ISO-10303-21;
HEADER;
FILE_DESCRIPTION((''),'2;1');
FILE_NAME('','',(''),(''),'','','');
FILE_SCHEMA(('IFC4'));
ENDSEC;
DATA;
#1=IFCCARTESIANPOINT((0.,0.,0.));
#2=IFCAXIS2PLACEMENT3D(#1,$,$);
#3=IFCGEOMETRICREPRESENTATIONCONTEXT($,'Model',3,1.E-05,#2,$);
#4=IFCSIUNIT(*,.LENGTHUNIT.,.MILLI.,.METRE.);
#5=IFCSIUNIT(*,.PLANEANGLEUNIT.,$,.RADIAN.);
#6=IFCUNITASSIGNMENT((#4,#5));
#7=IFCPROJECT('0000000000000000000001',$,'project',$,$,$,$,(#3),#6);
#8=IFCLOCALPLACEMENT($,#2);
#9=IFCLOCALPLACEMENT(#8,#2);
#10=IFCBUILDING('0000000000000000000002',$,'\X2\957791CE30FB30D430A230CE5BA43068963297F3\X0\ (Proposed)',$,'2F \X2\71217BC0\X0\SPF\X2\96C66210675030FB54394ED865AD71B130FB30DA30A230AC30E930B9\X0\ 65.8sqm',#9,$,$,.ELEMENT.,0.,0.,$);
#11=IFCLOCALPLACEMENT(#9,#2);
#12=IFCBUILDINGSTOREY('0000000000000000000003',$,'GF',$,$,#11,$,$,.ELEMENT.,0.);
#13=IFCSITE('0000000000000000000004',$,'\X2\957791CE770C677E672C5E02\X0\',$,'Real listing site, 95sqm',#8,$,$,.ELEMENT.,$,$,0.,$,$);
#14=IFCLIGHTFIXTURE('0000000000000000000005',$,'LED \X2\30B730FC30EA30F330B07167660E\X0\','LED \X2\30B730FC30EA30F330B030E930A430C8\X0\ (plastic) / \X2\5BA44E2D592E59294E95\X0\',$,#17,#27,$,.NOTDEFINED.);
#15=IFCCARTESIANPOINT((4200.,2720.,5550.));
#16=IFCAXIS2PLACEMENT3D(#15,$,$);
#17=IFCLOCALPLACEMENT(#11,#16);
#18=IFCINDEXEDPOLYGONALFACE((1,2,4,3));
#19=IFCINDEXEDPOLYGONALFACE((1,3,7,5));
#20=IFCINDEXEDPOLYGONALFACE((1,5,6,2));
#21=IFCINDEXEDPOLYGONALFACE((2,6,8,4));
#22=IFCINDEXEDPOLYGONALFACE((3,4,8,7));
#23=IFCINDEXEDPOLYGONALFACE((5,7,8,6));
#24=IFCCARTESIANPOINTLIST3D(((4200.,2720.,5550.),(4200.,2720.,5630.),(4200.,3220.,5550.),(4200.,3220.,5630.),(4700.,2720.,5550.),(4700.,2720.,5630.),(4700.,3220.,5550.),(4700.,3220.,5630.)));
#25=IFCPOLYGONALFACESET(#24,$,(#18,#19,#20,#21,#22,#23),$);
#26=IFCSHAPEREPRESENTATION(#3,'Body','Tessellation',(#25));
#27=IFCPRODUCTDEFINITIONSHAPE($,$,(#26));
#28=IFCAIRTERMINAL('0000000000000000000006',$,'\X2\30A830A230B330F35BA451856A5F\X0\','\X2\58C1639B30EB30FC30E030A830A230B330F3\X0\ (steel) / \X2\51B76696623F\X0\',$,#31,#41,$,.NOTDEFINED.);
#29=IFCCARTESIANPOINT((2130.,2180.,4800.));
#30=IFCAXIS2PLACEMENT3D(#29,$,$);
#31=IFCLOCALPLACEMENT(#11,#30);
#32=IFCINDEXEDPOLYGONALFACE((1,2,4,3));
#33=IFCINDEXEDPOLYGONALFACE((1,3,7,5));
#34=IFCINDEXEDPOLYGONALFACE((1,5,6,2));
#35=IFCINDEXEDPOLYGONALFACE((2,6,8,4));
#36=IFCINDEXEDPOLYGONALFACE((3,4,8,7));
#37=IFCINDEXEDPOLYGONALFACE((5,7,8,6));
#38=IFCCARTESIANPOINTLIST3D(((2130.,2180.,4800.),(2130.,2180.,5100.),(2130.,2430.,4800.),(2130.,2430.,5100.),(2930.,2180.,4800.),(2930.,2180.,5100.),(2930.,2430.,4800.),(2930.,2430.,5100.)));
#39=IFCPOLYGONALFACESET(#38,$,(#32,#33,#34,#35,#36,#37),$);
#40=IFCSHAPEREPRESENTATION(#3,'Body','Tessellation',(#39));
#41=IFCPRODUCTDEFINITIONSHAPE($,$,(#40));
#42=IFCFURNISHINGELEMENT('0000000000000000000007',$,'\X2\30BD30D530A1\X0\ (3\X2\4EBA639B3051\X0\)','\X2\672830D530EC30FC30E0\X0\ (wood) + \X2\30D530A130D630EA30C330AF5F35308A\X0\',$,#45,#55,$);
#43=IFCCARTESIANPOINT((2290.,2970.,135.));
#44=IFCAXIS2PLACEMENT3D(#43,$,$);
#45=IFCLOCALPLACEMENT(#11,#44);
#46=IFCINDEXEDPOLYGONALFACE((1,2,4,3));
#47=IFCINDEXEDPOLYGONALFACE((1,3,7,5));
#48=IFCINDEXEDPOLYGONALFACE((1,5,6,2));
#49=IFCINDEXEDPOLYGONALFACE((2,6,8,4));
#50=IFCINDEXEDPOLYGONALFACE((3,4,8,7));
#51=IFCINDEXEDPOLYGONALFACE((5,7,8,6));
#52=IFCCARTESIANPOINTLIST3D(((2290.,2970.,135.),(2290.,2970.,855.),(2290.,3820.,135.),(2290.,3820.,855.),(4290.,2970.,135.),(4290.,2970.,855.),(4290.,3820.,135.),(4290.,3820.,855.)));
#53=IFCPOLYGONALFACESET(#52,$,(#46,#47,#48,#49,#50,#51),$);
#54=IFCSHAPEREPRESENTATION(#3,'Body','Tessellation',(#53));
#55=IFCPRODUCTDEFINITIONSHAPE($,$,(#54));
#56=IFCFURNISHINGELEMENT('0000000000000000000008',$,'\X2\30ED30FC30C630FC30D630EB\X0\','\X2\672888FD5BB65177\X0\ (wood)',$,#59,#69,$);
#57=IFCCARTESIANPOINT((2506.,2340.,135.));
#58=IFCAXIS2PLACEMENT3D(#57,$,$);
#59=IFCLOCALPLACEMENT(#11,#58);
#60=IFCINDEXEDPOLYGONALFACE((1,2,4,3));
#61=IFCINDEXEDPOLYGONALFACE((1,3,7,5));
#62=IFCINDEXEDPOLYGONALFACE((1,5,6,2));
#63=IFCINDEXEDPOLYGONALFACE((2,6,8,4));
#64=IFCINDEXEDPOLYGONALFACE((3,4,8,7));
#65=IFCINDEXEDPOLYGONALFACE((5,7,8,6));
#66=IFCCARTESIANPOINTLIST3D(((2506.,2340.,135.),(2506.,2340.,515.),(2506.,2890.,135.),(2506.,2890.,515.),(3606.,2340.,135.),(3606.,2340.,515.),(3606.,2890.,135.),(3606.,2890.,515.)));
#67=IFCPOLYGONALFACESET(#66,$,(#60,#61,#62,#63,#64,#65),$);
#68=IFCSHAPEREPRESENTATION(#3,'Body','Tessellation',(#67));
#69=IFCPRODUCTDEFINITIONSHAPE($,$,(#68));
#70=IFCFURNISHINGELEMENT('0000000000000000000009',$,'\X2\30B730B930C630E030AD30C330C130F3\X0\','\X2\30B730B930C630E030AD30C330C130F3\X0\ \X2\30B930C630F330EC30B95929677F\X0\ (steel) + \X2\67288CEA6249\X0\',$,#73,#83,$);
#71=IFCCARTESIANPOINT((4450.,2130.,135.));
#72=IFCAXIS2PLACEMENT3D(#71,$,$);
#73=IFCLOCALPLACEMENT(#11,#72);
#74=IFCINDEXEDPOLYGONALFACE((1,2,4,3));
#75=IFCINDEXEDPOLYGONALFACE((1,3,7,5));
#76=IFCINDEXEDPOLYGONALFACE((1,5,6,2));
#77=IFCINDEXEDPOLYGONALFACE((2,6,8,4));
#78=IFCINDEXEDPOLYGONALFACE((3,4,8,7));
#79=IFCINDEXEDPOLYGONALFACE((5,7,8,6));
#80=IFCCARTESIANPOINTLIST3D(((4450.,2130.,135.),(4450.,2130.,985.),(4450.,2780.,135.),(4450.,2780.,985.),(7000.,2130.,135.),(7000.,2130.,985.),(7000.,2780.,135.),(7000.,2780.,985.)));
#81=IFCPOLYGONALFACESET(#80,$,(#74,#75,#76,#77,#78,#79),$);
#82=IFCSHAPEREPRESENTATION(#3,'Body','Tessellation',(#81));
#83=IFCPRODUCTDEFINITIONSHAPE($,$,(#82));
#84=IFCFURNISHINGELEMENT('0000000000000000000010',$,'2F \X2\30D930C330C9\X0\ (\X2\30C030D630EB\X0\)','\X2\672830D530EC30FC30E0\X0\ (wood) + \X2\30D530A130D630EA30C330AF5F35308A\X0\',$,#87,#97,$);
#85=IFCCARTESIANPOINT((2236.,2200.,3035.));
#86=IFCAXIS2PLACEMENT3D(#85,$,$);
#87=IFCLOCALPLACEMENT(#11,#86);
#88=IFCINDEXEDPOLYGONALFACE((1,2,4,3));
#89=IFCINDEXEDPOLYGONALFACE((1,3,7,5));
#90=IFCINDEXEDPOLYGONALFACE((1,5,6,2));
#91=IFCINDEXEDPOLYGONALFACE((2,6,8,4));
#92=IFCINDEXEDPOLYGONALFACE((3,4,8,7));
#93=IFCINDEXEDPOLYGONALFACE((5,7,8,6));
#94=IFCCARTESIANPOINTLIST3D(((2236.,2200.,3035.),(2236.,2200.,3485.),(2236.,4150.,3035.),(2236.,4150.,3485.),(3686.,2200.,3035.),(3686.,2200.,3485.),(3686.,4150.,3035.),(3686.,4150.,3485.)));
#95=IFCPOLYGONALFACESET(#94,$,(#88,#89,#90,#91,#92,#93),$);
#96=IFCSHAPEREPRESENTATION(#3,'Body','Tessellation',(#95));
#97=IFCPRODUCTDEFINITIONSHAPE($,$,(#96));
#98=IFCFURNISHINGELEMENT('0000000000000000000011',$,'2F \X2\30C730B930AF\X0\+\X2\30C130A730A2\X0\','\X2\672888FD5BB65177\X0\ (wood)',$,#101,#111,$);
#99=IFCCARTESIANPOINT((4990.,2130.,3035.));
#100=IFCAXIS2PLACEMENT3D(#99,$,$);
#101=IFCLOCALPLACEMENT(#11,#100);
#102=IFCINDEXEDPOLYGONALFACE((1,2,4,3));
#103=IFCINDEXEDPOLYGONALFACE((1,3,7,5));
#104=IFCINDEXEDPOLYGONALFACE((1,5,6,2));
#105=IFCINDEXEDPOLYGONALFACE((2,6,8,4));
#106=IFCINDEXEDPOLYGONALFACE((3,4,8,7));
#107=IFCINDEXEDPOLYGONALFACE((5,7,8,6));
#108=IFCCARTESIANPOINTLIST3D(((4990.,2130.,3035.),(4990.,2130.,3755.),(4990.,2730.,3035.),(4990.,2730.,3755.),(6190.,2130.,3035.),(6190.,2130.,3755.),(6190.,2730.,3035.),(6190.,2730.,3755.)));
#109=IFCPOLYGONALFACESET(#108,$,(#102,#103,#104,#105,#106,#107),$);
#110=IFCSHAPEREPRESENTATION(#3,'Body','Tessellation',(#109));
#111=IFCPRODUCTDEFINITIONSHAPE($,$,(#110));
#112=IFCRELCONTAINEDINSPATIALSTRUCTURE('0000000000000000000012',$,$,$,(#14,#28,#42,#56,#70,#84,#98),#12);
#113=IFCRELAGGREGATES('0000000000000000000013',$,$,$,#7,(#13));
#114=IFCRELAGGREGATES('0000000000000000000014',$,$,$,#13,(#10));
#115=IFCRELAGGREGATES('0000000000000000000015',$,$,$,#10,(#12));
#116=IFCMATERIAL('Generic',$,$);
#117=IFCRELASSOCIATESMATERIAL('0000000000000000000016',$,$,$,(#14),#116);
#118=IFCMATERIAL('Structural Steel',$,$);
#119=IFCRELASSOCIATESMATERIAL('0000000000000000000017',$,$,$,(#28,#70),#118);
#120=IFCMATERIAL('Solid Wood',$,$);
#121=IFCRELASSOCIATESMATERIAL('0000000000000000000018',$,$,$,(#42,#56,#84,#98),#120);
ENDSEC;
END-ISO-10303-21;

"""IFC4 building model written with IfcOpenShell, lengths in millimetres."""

from ifc_helpers import new_model, si_unit, frame, frame_2d, origin, place, context, project, spatial, rectangle, extrude, material, element, save


model = new_model("IFC4")

# Units and contexts
model_context = context("Model", 3, precision=1e-05, world=origin())
ifc_project = project(units=[si_unit("LENGTHUNIT", "METRE", prefix="MILLI"), si_unit("PLANEANGLEUNIT", "RADIAN")], contexts=[model_context])

# Site, building, storey
site_placement = place(None, origin())
site = spatial("IfcSite", under=ifc_project, at=site_placement, Name="長野県松本市", ObjectType="Real listing site, 95sqm", CompositionType="ELEMENT", RefElevation=0.0)
building_placement = place(site_placement, origin())
building = spatial("IfcBuilding", under=site, at=building_placement, Name="長野・ピアノ室と防音 (Proposed)", ObjectType="2F 無節SPF集成材・吹付断熱・ペアガラス 65.8sqm", CompositionType="ELEMENT", ElevationOfRefHeight=0.0, ElevationOfTerrain=0.0)
storey_placement = place(building_placement, origin())
storey = spatial("IfcBuildingStorey", under=building, at=storey_placement, Name="GF", CompositionType="ELEMENT", Elevation=0.0)

# Shared definitions
ifc_material_1 = material(Name="Solid Wood")

# Shared definitions
ifc_material_2 = material(Name="Generic")

# Shared definitions
ifc_material_3 = material(Name="Structural Steel")

# Light fixture
light_fixture_1_placement = place(storey_placement, frame((4200.0, 2720.0, 5550.0)))
element("IfcLightFixture", 1, at=light_fixture_1_placement, inside=storey, material=ifc_material_2, Name="LED シーリング照明", Description="LED シーリングライト (plastic) / 室中央天井", PredefinedType="NOTDEFINED", context=model_context, shape_type="SweptSolid", body=[
    extrude(rectangle(XDim=500.0, YDim=500.0, at=frame_2d((250.0, 250.0))), frame((4200.0, 2720.0, 5550.0)), (0.0, 0.0, 1.0), 80.0),
])

# Air terminal
air_terminal_placement = place(storey_placement, frame((2130.0, 2180.0, 4800.0)))
element("IfcAirTerminal", 2, at=air_terminal_placement, inside=storey, material=ifc_material_3, Name="エアコン室内機", Description="壁掛ルームエアコン (steel) / 冷暖房", PredefinedType="NOTDEFINED", context=model_context, shape_type="SweptSolid", body=[
    extrude(rectangle(XDim=800.0, YDim=250.0, at=frame_2d((400.0, 125.0))), frame((2130.0, 2180.0, 4800.0)), (0.0, 0.0, 1.0), 300.0),
])

# Furnishing elements
furnishing_1_placement = place(storey_placement, frame((2290.0, 2970.0, 135.0)))
element("IfcFurnishingElement", 3, at=furnishing_1_placement, inside=storey, material=ifc_material_1, Name="ソファ (3人掛け)", Description="木フレーム (wood) + ファブリック張り", context=model_context, shape_type="SweptSolid", body=[
    extrude(rectangle(XDim=2000.0, YDim=850.0, at=frame_2d((1000.0, 425.0))), frame((2290.0, 2970.0, 135.0)), (0.0, 0.0, 1.0), 720.0),
])
furnishing_2_placement = place(storey_placement, frame((2506.0, 2340.0, 135.0)))
element("IfcFurnishingElement", 4, at=furnishing_2_placement, inside=storey, material=ifc_material_1, Name="ローテーブル", Description="木製家具 (wood)", context=model_context, shape_type="SweptSolid", body=[
    extrude(rectangle(XDim=1100.0, YDim=550.0, at=frame_2d((550.0, 275.0))), frame((2506.0, 2340.0, 135.0)), (0.0, 0.0, 1.0), 380.0),
])
furnishing_3_placement = place(storey_placement, frame((4450.0, 2130.0, 135.0)))
element("IfcFurnishingElement", 5, at=furnishing_3_placement, inside=storey, material=ifc_material_3, Name="システムキッチン", Description="システムキッチン ステンレス天板 (steel) + 木質扉", context=model_context, shape_type="SweptSolid", body=[
    extrude(rectangle(XDim=2550.0, YDim=650.0, at=frame_2d((1275.0, 325.0))), frame((4450.0, 2130.0, 135.0)), (0.0, 0.0, 1.0), 850.0),
])
furnishing_4_placement = place(storey_placement, frame((2236.0, 2200.0, 3035.0)))
element("IfcFurnishingElement", 6, at=furnishing_4_placement, inside=storey, material=ifc_material_1, Name="2F ベッド (ダブル)", Description="木フレーム (wood) + ファブリック張り", context=model_context, shape_type="SweptSolid", body=[
    extrude(rectangle(XDim=1450.0, YDim=1950.0, at=frame_2d((725.0, 975.0))), frame((2236.0, 2200.0, 3035.0)), (0.0, 0.0, 1.0), 450.0),
])
furnishing_5_placement = place(storey_placement, frame((4990.0, 2130.0, 3035.0)))
element("IfcFurnishingElement", 7, at=furnishing_5_placement, inside=storey, material=ifc_material_1, Name="2F デスク+チェア", Description="木製家具 (wood)", context=model_context, shape_type="SweptSolid", body=[
    extrude(rectangle(XDim=1200.0, YDim=600.0, at=frame_2d((600.0, 300.0))), frame((4990.0, 2130.0, 3035.0)), (0.0, 0.0, 1.0), 720.0),
])

save(model, "model.ifc")
